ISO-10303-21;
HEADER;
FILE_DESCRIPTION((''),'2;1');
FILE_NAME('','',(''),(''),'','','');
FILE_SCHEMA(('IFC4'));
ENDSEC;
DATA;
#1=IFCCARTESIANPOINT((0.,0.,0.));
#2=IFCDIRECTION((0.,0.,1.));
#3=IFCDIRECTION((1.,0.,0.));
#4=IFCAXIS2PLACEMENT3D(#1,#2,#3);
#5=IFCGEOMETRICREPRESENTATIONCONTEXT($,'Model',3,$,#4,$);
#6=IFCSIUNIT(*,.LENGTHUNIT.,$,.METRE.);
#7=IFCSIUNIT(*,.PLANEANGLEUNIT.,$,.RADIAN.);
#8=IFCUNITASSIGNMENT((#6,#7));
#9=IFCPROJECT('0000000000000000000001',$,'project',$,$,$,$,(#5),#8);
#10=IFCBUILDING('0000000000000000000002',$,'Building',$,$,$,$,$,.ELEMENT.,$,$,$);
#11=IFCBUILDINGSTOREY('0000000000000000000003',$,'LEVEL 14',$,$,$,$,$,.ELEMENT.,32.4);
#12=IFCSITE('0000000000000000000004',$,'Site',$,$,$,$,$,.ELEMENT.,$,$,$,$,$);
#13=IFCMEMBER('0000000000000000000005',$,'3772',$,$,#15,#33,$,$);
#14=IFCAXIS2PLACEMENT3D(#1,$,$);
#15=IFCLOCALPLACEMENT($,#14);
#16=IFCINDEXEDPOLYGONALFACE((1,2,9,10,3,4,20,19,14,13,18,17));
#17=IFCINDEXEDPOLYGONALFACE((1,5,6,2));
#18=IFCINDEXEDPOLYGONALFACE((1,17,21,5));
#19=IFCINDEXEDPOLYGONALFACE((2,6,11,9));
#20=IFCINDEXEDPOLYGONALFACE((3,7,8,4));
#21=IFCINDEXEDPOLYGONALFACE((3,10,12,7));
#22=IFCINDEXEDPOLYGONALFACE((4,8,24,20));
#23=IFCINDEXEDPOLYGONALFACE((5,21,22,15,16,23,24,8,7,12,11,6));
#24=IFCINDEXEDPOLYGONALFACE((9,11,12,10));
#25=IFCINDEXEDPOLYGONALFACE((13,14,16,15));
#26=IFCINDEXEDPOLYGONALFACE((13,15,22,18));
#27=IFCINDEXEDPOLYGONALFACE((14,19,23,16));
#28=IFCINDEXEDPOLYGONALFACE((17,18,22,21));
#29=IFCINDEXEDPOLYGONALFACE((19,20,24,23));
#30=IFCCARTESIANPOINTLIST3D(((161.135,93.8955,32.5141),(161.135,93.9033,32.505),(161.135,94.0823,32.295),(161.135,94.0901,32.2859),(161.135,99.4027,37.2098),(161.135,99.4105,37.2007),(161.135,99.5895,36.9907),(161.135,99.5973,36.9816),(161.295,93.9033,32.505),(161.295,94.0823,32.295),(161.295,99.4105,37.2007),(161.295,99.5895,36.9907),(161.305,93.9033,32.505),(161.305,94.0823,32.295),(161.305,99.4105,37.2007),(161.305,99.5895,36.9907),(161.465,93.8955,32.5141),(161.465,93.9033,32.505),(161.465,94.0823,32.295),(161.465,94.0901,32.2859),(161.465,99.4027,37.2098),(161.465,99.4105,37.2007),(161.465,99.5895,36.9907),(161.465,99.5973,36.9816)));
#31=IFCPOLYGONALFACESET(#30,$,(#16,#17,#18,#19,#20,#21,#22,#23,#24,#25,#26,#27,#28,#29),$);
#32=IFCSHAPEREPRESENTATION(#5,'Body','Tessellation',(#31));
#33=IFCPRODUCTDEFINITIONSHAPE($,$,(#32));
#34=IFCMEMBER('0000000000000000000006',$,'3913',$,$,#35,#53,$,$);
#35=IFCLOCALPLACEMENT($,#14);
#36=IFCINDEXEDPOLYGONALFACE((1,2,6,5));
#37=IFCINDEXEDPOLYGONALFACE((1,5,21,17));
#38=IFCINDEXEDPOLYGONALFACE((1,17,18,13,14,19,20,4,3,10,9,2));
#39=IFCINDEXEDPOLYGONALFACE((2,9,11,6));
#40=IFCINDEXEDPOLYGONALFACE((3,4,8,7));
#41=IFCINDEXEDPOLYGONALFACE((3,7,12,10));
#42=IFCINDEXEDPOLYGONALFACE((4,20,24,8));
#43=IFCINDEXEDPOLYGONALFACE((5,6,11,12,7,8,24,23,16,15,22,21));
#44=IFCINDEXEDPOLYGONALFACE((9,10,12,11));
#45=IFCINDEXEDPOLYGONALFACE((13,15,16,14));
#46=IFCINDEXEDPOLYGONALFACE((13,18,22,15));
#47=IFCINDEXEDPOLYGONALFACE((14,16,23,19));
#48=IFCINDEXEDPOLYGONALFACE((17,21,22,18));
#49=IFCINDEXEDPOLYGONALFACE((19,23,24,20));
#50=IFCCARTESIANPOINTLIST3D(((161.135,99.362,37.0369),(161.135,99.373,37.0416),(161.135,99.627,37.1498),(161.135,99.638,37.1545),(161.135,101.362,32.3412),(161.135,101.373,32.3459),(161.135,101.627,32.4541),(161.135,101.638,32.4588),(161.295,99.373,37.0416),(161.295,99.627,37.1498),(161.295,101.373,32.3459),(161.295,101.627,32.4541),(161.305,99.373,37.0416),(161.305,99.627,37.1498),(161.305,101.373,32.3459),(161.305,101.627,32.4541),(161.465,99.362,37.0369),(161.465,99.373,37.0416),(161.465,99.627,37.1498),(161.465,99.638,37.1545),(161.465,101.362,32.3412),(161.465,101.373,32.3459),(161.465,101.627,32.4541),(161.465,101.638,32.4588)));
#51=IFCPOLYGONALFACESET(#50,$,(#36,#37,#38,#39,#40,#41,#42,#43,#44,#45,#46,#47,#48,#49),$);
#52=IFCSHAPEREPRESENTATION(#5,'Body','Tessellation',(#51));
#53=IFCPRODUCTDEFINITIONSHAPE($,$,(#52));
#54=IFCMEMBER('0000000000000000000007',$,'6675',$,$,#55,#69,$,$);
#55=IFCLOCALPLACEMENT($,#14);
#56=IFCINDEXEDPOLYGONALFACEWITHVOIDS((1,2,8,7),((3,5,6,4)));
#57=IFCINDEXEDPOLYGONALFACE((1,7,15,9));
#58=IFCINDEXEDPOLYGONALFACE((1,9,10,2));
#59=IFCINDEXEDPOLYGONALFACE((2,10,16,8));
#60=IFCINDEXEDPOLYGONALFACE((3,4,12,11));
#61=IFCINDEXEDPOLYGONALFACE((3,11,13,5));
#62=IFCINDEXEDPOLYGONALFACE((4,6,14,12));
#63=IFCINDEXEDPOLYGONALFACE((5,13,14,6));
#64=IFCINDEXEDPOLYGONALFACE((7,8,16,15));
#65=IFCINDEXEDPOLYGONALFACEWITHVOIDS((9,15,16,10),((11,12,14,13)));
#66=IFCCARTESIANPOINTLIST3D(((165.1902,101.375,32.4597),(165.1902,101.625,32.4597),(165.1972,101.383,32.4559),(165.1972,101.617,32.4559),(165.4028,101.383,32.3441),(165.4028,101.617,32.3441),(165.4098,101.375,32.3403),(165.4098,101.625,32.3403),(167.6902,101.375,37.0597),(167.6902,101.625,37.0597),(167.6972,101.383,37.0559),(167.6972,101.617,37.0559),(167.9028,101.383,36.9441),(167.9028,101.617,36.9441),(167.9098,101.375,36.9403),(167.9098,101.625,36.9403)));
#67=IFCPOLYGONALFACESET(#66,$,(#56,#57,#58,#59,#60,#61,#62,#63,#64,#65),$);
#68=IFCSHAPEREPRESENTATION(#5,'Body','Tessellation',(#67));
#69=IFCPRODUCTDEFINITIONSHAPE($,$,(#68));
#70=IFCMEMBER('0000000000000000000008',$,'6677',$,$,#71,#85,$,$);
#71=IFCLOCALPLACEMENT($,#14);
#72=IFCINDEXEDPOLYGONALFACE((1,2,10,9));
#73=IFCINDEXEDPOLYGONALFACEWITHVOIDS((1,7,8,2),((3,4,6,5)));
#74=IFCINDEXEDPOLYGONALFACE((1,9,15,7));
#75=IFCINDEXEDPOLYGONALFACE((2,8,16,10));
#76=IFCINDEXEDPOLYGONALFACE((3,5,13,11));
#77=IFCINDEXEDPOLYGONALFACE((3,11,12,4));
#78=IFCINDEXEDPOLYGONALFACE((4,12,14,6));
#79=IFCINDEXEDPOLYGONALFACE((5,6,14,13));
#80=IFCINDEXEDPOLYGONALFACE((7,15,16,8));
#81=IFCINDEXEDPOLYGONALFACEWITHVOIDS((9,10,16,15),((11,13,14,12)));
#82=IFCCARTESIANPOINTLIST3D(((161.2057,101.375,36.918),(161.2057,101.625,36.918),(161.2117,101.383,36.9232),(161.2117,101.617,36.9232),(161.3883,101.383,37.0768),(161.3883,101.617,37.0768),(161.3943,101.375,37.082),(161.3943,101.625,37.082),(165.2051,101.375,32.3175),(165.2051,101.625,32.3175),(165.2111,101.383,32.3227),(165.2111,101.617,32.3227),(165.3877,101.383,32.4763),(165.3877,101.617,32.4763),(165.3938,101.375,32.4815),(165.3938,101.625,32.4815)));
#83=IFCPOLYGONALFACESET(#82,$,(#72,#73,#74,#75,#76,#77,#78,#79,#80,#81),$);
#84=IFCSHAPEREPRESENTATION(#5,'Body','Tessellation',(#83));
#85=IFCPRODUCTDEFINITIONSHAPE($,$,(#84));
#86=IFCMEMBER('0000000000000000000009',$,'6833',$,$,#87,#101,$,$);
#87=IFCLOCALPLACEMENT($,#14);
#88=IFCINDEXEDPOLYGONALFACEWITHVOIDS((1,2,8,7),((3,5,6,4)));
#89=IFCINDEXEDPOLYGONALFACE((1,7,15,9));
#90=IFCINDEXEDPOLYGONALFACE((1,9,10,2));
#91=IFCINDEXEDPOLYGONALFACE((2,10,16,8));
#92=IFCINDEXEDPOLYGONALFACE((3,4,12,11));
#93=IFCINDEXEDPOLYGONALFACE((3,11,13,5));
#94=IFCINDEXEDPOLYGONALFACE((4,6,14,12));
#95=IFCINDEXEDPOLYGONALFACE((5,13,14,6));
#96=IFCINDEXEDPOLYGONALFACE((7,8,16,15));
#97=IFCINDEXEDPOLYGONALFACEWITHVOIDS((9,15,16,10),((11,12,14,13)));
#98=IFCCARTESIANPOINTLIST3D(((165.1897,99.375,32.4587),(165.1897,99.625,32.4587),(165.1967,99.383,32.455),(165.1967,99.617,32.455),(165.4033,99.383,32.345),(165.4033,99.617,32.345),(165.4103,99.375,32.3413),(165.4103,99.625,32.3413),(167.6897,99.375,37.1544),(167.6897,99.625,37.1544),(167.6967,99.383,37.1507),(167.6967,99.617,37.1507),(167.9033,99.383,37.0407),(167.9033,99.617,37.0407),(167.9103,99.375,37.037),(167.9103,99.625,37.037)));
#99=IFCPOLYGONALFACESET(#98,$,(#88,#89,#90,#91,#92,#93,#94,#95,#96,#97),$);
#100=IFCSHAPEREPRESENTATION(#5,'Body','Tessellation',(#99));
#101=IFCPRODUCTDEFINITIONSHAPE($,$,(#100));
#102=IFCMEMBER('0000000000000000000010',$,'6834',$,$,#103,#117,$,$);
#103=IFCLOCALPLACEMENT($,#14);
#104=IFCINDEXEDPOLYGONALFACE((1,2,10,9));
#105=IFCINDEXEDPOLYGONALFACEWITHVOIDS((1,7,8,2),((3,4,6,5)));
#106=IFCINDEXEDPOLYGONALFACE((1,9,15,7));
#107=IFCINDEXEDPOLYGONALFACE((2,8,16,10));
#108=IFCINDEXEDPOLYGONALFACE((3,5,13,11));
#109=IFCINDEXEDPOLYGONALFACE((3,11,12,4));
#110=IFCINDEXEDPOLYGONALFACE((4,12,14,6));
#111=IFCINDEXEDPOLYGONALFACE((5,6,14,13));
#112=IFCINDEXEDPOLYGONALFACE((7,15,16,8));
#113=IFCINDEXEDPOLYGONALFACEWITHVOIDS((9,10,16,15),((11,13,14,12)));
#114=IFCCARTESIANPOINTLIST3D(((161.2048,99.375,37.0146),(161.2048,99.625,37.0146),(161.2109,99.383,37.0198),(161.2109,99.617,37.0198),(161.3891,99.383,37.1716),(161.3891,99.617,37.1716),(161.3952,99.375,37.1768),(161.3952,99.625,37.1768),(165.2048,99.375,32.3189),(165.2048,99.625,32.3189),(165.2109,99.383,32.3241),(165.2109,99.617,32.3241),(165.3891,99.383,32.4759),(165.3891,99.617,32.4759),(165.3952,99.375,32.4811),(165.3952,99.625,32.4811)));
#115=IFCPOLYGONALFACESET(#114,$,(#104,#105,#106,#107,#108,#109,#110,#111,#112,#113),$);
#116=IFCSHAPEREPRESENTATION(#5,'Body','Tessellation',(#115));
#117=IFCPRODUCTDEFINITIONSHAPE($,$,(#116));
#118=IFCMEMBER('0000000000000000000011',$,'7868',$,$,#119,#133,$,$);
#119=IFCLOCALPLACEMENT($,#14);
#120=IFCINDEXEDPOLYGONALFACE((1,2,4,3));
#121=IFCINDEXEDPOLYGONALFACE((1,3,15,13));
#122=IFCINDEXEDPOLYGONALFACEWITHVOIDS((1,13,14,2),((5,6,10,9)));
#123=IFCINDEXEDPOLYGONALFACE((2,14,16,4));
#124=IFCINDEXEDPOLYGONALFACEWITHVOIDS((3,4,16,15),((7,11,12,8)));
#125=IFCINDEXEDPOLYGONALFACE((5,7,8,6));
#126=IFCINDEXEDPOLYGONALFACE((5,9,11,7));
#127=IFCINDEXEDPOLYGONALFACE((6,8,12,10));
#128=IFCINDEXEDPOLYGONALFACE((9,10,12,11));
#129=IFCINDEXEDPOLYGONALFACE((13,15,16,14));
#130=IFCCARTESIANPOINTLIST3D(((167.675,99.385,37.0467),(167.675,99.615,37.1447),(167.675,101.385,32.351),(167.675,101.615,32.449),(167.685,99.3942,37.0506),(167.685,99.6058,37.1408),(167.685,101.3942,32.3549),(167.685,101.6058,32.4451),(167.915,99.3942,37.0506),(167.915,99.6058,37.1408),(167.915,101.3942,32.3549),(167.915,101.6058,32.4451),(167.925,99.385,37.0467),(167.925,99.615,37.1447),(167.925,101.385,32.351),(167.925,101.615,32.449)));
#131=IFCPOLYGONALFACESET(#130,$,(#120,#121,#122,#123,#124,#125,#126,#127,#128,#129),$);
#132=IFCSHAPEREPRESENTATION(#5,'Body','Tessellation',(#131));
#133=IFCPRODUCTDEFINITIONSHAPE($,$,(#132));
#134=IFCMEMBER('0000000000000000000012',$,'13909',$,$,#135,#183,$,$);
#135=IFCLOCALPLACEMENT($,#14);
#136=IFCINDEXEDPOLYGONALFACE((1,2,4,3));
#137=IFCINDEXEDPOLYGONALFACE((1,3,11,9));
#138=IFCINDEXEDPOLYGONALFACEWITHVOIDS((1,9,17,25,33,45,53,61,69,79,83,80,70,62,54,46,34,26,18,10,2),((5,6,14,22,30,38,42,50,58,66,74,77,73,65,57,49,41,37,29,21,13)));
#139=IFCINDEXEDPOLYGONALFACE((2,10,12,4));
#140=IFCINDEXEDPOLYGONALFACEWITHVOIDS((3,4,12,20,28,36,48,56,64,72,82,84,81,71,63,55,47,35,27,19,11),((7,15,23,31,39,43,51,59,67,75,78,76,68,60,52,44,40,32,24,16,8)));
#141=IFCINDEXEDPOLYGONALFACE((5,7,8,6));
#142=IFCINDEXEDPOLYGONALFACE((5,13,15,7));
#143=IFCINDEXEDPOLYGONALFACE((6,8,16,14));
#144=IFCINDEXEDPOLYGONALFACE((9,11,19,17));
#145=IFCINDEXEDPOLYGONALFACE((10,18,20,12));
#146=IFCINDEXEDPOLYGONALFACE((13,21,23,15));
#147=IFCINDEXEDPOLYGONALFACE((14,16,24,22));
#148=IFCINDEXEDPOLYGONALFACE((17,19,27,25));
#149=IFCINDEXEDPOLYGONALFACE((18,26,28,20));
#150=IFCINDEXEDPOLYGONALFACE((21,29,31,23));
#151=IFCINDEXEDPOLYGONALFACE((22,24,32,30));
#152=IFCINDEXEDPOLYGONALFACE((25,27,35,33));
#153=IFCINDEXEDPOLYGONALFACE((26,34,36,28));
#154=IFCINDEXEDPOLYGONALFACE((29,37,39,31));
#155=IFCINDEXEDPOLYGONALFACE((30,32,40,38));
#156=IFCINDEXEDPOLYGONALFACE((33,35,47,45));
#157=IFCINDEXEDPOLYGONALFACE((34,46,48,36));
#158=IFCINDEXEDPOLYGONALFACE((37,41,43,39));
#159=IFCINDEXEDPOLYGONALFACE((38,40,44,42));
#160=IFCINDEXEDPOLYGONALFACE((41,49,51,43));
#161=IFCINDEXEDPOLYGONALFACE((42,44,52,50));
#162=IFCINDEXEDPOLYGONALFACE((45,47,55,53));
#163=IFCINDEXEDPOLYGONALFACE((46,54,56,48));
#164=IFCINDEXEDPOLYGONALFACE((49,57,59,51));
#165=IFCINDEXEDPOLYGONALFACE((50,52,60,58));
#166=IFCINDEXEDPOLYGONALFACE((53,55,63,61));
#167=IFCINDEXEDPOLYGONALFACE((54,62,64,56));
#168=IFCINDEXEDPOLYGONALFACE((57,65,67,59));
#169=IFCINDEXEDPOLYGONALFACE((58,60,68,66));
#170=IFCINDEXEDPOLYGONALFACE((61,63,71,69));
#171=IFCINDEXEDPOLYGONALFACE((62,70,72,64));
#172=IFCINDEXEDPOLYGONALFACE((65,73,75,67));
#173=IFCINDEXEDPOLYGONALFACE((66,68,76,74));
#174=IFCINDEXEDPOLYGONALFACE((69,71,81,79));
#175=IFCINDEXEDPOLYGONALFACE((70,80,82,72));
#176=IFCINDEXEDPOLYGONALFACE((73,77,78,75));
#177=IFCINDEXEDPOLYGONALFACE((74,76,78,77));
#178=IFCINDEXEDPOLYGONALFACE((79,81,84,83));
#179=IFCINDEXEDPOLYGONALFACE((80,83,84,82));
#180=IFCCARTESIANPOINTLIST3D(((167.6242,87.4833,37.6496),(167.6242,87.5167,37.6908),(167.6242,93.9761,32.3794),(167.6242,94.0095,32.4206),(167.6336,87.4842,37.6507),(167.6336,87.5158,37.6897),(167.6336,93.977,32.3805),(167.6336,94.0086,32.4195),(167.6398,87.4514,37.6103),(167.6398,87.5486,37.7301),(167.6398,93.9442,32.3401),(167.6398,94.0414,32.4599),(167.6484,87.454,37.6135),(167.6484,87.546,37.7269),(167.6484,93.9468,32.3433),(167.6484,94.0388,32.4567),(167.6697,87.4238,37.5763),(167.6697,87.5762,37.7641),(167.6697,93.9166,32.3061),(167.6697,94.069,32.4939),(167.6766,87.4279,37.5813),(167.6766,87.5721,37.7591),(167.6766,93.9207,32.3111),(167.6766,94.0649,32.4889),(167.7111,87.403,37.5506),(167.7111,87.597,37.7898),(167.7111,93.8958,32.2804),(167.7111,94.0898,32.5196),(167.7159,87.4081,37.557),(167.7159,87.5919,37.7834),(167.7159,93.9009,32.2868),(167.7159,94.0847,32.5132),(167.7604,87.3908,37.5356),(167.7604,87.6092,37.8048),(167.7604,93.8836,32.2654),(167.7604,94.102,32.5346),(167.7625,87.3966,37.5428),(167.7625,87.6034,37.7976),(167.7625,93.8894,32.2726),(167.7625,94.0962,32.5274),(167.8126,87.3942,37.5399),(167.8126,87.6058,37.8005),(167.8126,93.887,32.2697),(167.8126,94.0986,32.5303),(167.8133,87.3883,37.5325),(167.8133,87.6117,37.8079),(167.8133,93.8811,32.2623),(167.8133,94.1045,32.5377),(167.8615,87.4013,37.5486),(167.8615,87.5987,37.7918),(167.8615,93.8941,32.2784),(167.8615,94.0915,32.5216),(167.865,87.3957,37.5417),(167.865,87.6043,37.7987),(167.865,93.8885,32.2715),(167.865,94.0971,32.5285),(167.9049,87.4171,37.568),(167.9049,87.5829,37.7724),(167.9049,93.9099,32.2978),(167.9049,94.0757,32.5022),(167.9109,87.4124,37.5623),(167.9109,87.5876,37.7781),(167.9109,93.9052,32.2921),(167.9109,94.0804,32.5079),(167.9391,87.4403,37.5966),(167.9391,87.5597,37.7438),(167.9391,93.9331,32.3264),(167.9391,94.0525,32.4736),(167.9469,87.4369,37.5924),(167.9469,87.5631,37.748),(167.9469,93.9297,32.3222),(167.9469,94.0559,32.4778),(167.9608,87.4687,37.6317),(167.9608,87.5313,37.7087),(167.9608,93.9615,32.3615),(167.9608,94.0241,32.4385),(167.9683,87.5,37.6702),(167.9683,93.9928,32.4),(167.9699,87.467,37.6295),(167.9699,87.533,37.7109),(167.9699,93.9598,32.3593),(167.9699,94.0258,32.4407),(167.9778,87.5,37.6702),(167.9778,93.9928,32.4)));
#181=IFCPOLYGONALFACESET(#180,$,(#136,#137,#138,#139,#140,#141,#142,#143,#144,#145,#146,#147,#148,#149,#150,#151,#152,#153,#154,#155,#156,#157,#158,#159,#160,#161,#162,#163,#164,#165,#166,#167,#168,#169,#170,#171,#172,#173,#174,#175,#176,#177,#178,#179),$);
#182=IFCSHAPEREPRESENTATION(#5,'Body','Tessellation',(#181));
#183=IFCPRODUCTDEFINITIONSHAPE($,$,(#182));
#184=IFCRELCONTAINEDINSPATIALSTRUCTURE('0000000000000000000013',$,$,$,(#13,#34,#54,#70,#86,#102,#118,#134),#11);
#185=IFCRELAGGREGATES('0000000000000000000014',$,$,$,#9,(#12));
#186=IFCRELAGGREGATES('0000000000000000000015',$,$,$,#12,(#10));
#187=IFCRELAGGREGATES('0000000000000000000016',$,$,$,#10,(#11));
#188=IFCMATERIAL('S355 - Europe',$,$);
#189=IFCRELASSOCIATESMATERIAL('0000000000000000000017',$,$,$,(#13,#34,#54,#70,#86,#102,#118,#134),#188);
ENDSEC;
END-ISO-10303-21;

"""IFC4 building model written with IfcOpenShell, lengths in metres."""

from ifc_helpers import new_model, si_unit, frame, origin_with_axes, origin_2d_with_axis, place, context, project, spatial, hollow_rectangle, hollow_circle, i_section, extrude, material, material_profile, profile_set, profile_usage, element, save


model = new_model("IFC4")

# Units and contexts
model_context = context("Model", 3, world=origin_with_axes())
ifc_project = project(units=[si_unit("LENGTHUNIT", "METRE"), si_unit("PLANEANGLEUNIT", "RADIAN")], contexts=[model_context])

# Site, building, storey
site = spatial("IfcSite", under=ifc_project, Name="Site", CompositionType="ELEMENT")
building = spatial("IfcBuilding", under=site, Name="Building", CompositionType="ELEMENT")
storey = spatial("IfcBuildingStorey", under=building, Name="LEVEL 14", CompositionType="ELEMENT", Elevation=32.4)

# Shared definitions
ifc_material = material(Name="S355 - Europe")

# Members
ifc_material_profile_1 = material_profile(ifc_material, i_section(OverallWidth=0.33, OverallDepth=0.3, WebThickness=0.01, FlangeThickness=0.012, at=origin_2d_with_axis()))
ifc_profile_set_1 = profile_set([ifc_material_profile_1])
ifc_profile_usage_1 = profile_usage(ifc_profile_set_1, cardinal=10)
member_1_placement = place(None, frame((161.3, 93.9928, 32.4), z_axis=(0.0, 0.760944, 0.648817), x_axis=(-1.0, 0.0, 0.0)))
element("IfcMember", 1, at=member_1_placement, inside=storey, material=ifc_profile_usage_1, Name="3772", context=model_context, shape_type="SweptSolid", body=[
    extrude(i_section(OverallWidth=0.33, OverallDepth=0.3, WebThickness=0.01, FlangeThickness=0.012, at=origin_2d_with_axis()), origin_with_axes(), (0.0, 0.0, 1.0), 7.2373),
])
ifc_material_profile_2 = material_profile(ifc_material, i_section(OverallWidth=0.33, OverallDepth=0.3, WebThickness=0.01, FlangeThickness=0.012, at=origin_2d_with_axis()))
ifc_profile_set_2 = profile_set([ifc_material_profile_2])
ifc_profile_usage_2 = profile_usage(ifc_profile_set_2, cardinal=10)
member_2_placement = place(None, frame((161.3, 99.5, 37.0957), z_axis=(0.0, 0.391859, -0.920025), x_axis=(-1.0, 0.0, 0.0)))
element("IfcMember", 2, at=member_2_placement, inside=storey, material=ifc_profile_usage_2, Name="3913", context=model_context, shape_type="SweptSolid", body=[
    extrude(i_section(OverallWidth=0.33, OverallDepth=0.3, WebThickness=0.01, FlangeThickness=0.012, at=origin_2d_with_axis()), origin_with_axes(), (0.0, 0.0, 1.0), 5.1039),
])
ifc_material_profile_3 = material_profile(ifc_material, hollow_rectangle(XDim=0.25, YDim=0.25, WallThickness=0.008, at=origin_2d_with_axis()))
ifc_profile_set_3 = profile_set([ifc_material_profile_3])
ifc_profile_usage_3 = profile_usage(ifc_profile_set_3, cardinal=10)
member_3_placement = place(None, frame((165.3, 101.5, 32.4), z_axis=(0.477513, 0.0, 0.878625), x_axis=(0.0, 1.0, 0.0)))
element("IfcMember", 3, at=member_3_placement, inside=storey, material=ifc_profile_usage_3, Name="6675", context=model_context, shape_type="SweptSolid", body=[
    extrude(hollow_rectangle(XDim=0.25, YDim=0.25, WallThickness=0.008, at=origin_2d_with_axis()), origin_with_axes(), (0.0, 0.0, 1.0), 5.2355),
])
ifc_material_profile_4 = material_profile(ifc_material, hollow_rectangle(XDim=0.25, YDim=0.25, WallThickness=0.008, at=origin_2d_with_axis()))
ifc_profile_set_4 = profile_set([ifc_material_profile_4])
ifc_profile_usage_4 = profile_usage(ifc_profile_set_4, cardinal=10)
member_4_placement = place(None, frame((161.3, 101.5, 37.0), z_axis=(0.656085, 0.0, -0.754687), x_axis=(0.0, 1.0, 0.0)))
element("IfcMember", 4, at=member_4_placement, inside=storey, material=ifc_profile_usage_4, Name="6677", context=model_context, shape_type="SweptSolid", body=[
    extrude(hollow_rectangle(XDim=0.25, YDim=0.25, WallThickness=0.008, at=origin_2d_with_axis()), origin_with_axes(), (0.0, 0.0, 1.0), 6.0959),
])
ifc_material_profile_5 = material_profile(ifc_material, hollow_rectangle(XDim=0.25, YDim=0.25, WallThickness=0.008, at=origin_2d_with_axis()))
ifc_profile_set_5 = profile_set([ifc_material_profile_5])
ifc_profile_usage_5 = profile_usage(ifc_profile_set_5, cardinal=10)
member_5_placement = place(None, frame((167.8, 99.5, 37.0957), z_axis=(-0.469948, 0.0, -0.882694), x_axis=(0.0, -1.0, 0.0)))
element("IfcMember", 5, at=member_5_placement, inside=storey, material=ifc_profile_usage_5, Name="6833", context=model_context, shape_type="SweptSolid", body=[
    extrude(hollow_rectangle(XDim=0.25, YDim=0.25, WallThickness=0.008, at=origin_2d_with_axis()), origin_with_axes(), (0.0, 0.0, 1.0), 5.3197),
])
ifc_material_profile_6 = material_profile(ifc_material, hollow_rectangle(XDim=0.25, YDim=0.25, WallThickness=0.008, at=origin_2d_with_axis()))
ifc_profile_set_6 = profile_set([ifc_material_profile_6])
ifc_profile_usage_6 = profile_usage(ifc_profile_set_6, cardinal=10)
member_6_placement = place(None, frame((165.3, 99.5, 32.4), z_axis=(-0.648463, 0.0, 0.761246), x_axis=(0.0, -1.0, 0.0)))
element("IfcMember", 6, at=member_6_placement, inside=storey, material=ifc_profile_usage_6, Name="6834", context=model_context, shape_type="SweptSolid", body=[
    extrude(hollow_rectangle(XDim=0.25, YDim=0.25, WallThickness=0.008, at=origin_2d_with_axis()), origin_with_axes(), (0.0, 0.0, 1.0), 6.1684),
])
ifc_material_profile_7 = material_profile(ifc_material, hollow_rectangle(XDim=0.25, YDim=0.25, WallThickness=0.01, at=origin_2d_with_axis()))
ifc_profile_set_7 = profile_set([ifc_material_profile_7])
ifc_profile_usage_7 = profile_usage(ifc_profile_set_7, cardinal=10)
member_7_placement = place(None, frame((167.8, 99.5, 37.0957), z_axis=(0.0, 0.391859, -0.920025), x_axis=(-1.0, 0.0, 0.0)))
element("IfcMember", 7, at=member_7_placement, inside=storey, material=ifc_profile_usage_7, Name="7868", context=model_context, shape_type="SweptSolid", body=[
    extrude(hollow_rectangle(XDim=0.25, YDim=0.25, WallThickness=0.01, at=origin_2d_with_axis()), origin_with_axes(), (0.0, 0.0, 1.0), 5.1039),
])
ifc_material_profile_8 = material_profile(ifc_material, hollow_circle(Radius=0.1778, WallThickness=0.0095, at=origin_2d_with_axis()))
ifc_profile_set_8 = profile_set([ifc_material_profile_8])
ifc_profile_usage_8 = profile_usage(ifc_profile_set_8, cardinal=10)
member_8_placement = place(None, frame((167.8, 93.9928, 32.4), z_axis=(0.0, -0.776418, 0.630218), x_axis=(1.0, 0.0, 0.0)))
element("IfcMember", 8, at=member_8_placement, inside=storey, material=ifc_profile_usage_8, Name="13909", context=model_context, shape_type="SweptSolid", body=[
    extrude(hollow_circle(Radius=0.1778, WallThickness=0.0095, at=origin_2d_with_axis()), origin_with_axes(), (0.0, 0.0, 1.0), 8.3625),
])

save(model, "model.ifc")
